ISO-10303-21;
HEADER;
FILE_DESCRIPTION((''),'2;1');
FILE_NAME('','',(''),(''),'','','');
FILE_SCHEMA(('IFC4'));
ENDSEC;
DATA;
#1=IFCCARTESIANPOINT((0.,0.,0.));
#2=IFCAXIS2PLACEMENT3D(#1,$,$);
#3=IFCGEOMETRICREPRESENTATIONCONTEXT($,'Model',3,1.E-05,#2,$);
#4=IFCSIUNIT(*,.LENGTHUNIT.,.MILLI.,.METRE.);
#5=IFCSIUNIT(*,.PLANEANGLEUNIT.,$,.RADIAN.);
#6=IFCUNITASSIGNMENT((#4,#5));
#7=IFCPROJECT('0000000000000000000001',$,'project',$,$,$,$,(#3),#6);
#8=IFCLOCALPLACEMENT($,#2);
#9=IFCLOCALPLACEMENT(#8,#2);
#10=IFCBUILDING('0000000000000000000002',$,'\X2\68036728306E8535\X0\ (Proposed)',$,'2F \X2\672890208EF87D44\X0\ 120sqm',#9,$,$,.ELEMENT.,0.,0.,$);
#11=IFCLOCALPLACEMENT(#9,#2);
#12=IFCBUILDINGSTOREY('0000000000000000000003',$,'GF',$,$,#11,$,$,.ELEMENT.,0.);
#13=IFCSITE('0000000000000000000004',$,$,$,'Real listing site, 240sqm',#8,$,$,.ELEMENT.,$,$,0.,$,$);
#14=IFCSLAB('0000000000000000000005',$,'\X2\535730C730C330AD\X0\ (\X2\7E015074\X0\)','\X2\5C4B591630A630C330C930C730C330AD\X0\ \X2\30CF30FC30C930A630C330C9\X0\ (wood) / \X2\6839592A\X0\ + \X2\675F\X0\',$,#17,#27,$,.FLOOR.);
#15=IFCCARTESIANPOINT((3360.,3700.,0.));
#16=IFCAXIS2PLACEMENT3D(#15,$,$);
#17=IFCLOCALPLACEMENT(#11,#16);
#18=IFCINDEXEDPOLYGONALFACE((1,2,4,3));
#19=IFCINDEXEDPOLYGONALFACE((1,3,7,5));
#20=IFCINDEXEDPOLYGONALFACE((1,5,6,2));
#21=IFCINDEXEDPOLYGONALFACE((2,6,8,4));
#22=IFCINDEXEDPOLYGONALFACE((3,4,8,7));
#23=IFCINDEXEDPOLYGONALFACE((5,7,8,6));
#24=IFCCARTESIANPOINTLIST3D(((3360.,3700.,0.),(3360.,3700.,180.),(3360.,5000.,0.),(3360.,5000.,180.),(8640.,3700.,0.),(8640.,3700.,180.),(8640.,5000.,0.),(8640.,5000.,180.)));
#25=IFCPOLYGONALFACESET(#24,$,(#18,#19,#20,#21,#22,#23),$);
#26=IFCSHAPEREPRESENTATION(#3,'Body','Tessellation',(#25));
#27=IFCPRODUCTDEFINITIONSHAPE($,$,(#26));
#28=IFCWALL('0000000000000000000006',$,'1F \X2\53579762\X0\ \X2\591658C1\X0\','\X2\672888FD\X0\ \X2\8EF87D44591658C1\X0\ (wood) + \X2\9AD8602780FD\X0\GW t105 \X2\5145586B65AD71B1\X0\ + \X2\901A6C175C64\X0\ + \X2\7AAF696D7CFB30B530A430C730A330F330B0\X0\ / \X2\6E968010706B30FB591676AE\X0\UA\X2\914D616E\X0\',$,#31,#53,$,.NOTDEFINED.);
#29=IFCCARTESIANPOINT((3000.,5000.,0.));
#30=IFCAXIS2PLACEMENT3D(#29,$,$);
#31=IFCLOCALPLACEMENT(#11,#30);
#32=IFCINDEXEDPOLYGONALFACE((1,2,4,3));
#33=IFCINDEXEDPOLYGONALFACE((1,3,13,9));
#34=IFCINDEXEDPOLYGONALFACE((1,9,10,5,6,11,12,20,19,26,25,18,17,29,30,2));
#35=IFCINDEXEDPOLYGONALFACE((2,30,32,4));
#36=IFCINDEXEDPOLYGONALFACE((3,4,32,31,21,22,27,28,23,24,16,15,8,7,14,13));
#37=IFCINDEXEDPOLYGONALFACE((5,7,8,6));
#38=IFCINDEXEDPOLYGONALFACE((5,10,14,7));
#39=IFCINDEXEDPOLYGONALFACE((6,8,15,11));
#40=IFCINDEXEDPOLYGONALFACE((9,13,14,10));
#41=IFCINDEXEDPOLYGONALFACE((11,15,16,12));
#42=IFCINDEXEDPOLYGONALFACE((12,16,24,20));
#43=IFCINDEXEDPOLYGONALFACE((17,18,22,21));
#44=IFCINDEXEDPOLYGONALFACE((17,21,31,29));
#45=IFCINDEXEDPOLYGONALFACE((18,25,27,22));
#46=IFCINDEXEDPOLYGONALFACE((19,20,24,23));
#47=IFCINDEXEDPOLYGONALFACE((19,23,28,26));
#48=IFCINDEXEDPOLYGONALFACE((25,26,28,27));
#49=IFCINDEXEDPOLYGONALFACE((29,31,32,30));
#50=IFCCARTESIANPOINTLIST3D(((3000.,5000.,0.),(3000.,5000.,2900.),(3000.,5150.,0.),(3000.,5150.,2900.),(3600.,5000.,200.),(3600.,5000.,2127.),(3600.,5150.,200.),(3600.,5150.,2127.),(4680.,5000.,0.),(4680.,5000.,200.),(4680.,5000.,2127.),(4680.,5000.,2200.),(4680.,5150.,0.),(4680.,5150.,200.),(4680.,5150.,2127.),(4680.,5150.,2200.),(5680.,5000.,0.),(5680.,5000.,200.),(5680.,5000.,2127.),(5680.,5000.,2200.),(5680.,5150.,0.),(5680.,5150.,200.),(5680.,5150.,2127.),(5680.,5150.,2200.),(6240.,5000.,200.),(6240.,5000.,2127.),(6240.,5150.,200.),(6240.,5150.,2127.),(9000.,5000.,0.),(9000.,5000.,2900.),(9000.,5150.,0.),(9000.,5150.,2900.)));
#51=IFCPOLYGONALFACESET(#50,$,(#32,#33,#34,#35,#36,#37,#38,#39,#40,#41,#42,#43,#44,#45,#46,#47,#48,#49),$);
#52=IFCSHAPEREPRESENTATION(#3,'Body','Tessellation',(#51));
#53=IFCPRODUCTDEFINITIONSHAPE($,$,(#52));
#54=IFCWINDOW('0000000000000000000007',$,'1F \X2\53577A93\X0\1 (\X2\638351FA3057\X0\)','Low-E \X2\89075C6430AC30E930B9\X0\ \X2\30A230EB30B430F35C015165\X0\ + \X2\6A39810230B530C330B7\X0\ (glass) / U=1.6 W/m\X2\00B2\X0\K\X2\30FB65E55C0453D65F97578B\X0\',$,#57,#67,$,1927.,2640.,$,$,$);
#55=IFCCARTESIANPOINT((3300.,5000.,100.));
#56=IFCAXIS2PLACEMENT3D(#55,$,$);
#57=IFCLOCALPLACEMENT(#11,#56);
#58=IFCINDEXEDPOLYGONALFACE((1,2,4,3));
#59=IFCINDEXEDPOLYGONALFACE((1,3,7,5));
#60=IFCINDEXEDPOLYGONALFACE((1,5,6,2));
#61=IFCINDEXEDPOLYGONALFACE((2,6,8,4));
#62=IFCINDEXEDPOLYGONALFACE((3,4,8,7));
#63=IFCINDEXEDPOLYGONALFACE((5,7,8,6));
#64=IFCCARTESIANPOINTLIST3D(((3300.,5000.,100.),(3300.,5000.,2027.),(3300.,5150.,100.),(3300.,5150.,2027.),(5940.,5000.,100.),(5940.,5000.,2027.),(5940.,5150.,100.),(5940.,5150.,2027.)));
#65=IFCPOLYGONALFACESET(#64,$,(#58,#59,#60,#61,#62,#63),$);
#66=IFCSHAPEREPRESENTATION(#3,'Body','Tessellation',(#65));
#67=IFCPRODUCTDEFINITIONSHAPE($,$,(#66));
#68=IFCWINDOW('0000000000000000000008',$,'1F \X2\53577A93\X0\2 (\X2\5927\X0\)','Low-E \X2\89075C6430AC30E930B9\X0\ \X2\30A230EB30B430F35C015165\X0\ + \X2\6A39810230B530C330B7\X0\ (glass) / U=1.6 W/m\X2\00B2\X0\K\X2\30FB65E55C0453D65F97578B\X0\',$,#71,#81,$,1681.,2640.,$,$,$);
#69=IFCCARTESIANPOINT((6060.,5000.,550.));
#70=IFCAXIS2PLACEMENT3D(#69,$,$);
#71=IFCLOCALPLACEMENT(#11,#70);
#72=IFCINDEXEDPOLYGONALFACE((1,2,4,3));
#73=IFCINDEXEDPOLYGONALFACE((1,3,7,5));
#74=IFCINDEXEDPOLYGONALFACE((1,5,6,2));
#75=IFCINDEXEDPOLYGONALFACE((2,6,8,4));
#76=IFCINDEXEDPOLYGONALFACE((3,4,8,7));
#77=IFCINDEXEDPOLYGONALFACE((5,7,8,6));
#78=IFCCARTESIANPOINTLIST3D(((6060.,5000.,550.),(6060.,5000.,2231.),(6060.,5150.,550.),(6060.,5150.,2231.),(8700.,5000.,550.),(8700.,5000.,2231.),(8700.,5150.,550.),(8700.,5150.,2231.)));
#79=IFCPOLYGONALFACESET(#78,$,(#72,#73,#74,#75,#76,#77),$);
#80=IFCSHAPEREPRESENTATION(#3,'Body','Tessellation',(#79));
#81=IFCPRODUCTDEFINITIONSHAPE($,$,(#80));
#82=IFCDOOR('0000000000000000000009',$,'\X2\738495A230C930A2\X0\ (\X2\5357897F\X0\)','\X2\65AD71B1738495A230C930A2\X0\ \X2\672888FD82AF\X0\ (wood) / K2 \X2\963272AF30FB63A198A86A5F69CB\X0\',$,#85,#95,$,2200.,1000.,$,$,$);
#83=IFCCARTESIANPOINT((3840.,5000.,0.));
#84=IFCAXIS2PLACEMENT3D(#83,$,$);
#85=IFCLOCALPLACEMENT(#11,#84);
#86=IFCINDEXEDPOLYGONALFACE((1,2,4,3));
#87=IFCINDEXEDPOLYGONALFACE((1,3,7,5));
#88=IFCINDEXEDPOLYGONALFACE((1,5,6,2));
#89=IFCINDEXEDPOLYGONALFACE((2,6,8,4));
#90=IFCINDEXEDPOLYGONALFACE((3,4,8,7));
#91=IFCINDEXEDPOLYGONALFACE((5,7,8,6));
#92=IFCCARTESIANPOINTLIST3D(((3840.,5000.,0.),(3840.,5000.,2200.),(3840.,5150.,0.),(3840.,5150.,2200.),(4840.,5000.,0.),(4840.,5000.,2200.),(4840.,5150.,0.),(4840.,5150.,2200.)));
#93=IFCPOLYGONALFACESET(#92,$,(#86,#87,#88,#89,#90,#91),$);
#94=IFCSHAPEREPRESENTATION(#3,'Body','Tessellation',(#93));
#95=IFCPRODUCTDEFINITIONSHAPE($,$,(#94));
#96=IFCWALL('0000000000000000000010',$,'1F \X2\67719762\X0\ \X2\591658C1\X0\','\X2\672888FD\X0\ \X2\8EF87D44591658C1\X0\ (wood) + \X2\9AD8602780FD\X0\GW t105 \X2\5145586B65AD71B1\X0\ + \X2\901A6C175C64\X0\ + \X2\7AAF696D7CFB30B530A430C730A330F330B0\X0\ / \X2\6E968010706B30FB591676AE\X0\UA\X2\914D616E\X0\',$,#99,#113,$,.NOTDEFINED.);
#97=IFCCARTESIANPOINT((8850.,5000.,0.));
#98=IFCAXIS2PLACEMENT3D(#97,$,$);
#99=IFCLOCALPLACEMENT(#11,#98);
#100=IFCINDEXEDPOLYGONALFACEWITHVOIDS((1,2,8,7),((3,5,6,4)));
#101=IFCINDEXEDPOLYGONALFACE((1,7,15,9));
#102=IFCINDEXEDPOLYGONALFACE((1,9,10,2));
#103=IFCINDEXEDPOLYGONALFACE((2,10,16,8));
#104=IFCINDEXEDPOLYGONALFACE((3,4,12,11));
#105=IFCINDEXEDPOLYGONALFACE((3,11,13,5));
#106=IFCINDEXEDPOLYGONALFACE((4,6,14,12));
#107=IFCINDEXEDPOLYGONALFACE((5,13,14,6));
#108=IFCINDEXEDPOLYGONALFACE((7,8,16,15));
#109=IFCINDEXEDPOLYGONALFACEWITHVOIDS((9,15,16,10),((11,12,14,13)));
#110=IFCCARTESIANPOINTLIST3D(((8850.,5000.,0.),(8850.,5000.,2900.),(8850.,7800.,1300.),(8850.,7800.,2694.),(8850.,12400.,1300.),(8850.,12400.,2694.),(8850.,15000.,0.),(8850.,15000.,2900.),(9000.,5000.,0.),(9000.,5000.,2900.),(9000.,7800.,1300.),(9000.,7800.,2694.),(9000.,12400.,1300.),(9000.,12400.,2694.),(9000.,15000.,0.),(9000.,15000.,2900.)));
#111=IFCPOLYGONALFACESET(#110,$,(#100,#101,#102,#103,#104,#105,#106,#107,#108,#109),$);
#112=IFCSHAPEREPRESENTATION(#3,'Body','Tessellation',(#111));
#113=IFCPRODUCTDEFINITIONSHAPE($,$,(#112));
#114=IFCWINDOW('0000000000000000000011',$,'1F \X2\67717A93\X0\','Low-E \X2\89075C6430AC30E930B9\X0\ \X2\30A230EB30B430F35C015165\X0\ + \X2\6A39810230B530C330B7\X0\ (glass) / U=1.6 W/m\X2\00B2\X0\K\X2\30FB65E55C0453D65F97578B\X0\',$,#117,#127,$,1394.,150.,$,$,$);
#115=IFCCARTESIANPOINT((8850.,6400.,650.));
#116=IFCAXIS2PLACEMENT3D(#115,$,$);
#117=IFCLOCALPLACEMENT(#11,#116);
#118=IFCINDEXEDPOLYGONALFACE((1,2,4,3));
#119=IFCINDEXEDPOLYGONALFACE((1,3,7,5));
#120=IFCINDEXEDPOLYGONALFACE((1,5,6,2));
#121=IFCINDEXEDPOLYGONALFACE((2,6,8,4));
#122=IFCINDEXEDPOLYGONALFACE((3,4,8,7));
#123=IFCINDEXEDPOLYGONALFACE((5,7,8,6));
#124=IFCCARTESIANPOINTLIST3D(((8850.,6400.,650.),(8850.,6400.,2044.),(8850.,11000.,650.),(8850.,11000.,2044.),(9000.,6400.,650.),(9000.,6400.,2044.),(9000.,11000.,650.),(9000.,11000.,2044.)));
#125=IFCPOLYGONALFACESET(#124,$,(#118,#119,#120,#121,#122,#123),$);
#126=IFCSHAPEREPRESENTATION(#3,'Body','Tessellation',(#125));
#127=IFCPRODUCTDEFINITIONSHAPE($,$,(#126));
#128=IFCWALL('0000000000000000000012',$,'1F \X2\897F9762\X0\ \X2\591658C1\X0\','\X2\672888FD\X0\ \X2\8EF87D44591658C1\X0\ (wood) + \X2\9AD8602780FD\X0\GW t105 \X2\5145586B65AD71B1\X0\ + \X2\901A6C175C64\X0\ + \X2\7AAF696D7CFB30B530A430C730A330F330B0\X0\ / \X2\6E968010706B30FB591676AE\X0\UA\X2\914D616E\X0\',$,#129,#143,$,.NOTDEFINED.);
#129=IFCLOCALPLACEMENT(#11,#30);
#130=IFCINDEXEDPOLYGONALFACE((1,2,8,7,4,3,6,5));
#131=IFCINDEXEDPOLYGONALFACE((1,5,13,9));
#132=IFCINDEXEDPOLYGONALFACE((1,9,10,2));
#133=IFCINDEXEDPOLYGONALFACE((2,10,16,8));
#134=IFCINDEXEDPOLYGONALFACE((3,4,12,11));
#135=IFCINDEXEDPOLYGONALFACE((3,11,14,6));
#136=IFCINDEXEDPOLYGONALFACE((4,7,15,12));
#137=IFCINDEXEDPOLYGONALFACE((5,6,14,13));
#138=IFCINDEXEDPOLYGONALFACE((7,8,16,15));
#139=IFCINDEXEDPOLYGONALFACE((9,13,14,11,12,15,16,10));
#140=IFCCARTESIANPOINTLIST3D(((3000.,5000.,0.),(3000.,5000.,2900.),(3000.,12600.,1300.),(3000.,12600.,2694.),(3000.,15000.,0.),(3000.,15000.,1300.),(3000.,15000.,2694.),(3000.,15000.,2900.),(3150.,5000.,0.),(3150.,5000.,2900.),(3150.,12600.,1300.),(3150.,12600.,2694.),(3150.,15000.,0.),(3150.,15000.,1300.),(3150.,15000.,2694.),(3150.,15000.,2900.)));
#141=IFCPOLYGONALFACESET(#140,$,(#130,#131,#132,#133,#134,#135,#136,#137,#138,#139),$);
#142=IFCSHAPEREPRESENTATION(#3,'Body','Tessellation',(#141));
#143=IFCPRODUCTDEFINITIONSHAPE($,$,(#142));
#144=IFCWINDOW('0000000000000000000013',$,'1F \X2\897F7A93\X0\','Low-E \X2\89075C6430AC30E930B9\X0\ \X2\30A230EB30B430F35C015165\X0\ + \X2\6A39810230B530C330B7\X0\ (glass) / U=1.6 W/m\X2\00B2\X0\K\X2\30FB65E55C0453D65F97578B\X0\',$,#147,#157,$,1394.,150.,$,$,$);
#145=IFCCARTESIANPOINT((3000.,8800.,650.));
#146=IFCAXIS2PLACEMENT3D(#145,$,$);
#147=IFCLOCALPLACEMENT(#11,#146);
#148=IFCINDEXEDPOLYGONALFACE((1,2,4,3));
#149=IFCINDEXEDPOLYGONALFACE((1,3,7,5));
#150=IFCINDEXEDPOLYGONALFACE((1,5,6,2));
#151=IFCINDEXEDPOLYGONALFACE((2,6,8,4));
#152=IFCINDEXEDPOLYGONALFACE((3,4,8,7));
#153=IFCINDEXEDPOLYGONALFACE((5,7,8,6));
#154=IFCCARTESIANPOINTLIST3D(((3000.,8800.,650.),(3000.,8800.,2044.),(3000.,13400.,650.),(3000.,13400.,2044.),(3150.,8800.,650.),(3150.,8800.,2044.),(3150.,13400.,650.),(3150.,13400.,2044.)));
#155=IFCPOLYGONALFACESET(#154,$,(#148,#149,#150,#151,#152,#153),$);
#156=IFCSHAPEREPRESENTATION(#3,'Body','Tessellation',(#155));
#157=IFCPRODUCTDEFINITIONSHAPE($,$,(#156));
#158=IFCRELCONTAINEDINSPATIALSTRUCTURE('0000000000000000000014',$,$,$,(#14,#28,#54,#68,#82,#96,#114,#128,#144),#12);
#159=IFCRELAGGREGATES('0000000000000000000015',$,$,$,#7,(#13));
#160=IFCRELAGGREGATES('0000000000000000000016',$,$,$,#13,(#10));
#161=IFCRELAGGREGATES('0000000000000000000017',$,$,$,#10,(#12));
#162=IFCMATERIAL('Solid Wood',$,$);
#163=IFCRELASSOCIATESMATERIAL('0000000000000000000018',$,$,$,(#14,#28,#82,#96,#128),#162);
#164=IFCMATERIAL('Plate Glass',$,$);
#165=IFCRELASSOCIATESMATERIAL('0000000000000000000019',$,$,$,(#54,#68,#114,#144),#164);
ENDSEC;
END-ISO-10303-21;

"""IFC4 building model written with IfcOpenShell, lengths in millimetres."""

from ifc_helpers import new_model, si_unit, frame, frame_2d, origin, place, context, project, spatial, rectangle, extrude, material, element, fill, save


model = new_model("IFC4")

# Units and contexts
model_context = context("Model", 3, precision=1e-05, world=origin())
ifc_project = project(units=[si_unit("LENGTHUNIT", "METRE", prefix="MILLI"), si_unit("PLANEANGLEUNIT", "RADIAN")], contexts=[model_context])

# Site, building, storey
site_placement = place(None, origin())
site = spatial("IfcSite", under=ifc_project, at=site_placement, ObjectType="Real listing site, 240sqm", CompositionType="ELEMENT", RefElevation=0.0)
building_placement = place(site_placement, origin())
building = spatial("IfcBuilding", under=site, at=building_placement, Name="栃木の蔵 (Proposed)", ObjectType="2F 木造軸組 120sqm", CompositionType="ELEMENT", ElevationOfRefHeight=0.0, ElevationOfTerrain=0.0)
storey_placement = place(building_placement, origin())
storey = spatial("IfcBuildingStorey", under=building, at=storey_placement, Name="GF", CompositionType="ELEMENT", Elevation=0.0)

# Slab
ifc_material_1 = material(Name="Solid Wood")
slab_1_placement = place(storey_placement, frame((3360.0, 3700.0, 0.0)))
element("IfcSlab", 1, at=slab_1_placement, inside=storey, material=ifc_material_1, Name="南デッキ (縁側)", Description="屋外ウッドデッキ ハードウッド (wood) / 根太 + 束", PredefinedType="FLOOR", context=model_context, shape_type="SweptSolid", body=[
    extrude(rectangle(XDim=5280.0, YDim=1300.0, at=frame_2d((2640.0, 650.0))), frame((3360.0, 3700.0, 0.0)), (0.0, 0.0, 1.0), 180.0),
])

# Wall, openings, windows, door
wall_1_placement = place(storey_placement, frame((3000.0, 5000.0, 0.0)))
wall_1 = element("IfcWall", 2, at=wall_1_placement, inside=storey, material=ifc_material_1, Name="1F 南面 外壁", Description="木製 軸組外壁 (wood) + 高性能GW t105 充填断熱 + 通気層 + 窯業系サイディング / 準耐火・外皮UA配慮", PredefinedType="NOTDEFINED", context=model_context, shape_type="SweptSolid", body=[
    extrude(rectangle(XDim=6000.0, YDim=150.0, at=frame_2d((3000.0, 75.0))), frame((3000.0, 5000.0, 0.0)), (0.0, 0.0, 1.0), 2900.0),
])
opening_1_placement = place(storey_placement, frame((3300.0, 5000.0, 100.0)))
opening_1 = element("IfcOpeningElement", 3, at=opening_1_placement, cuts=wall_1, PredefinedType="NOTDEFINED", context=model_context, shape_type="SweptSolid", body=[
    extrude(rectangle(XDim=2640.0, YDim=150.0, at=frame_2d((1320.0, 75.0))), frame((3300.0, 5000.0, 100.0)), (0.0, 0.0, 1.0), 1927.0),
])
opening_2_placement = place(storey_placement, frame((6060.0, 5000.0, 550.0)))
opening_2 = element("IfcOpeningElement", 4, at=opening_2_placement, cuts=wall_1, PredefinedType="NOTDEFINED", context=model_context, shape_type="SweptSolid", body=[
    extrude(rectangle(XDim=2640.0, YDim=150.0, at=frame_2d((1320.0, 75.0))), frame((6060.0, 5000.0, 550.0)), (0.0, 0.0, 1.0), 1681.0),
])
opening_3_placement = place(storey_placement, frame((3840.0, 5000.0, 0.0)))
opening_3 = element("IfcOpeningElement", 5, at=opening_3_placement, cuts=wall_1, PredefinedType="NOTDEFINED", context=model_context, shape_type="SweptSolid", body=[
    extrude(rectangle(XDim=1000.0, YDim=150.0, at=frame_2d((500.0, 75.0))), frame((3840.0, 5000.0, 0.0)), (0.0, 0.0, 1.0), 2200.0),
])
ifc_material_2 = material(Name="Plate Glass")
window_1_placement = place(storey_placement, frame((3300.0, 5000.0, 100.0)))
window_1 = element("IfcWindow", 6, at=window_1_placement, inside=storey, material=ifc_material_2, Name="1F 南窓1 (掃出し)", Description="Low-E 複層ガラス アルゴン封入 + 樹脂サッシ (glass) / U=1.6 W/m²K・日射取得型", OverallHeight=1927.0, OverallWidth=2640.0, context=model_context, shape_type="SweptSolid", body=[
    extrude(rectangle(XDim=2640.0, YDim=150.0, at=frame_2d((1320.0, 75.0))), frame((3300.0, 5000.0, 100.0)), (0.0, 0.0, 1.0), 1927.0),
])
fill(opening_1, window_1)
window_2_placement = place(storey_placement, frame((6060.0, 5000.0, 550.0)))
window_2 = element("IfcWindow", 7, at=window_2_placement, inside=storey, material=ifc_material_2, Name="1F 南窓2 (大)", Description="Low-E 複層ガラス アルゴン封入 + 樹脂サッシ (glass) / U=1.6 W/m²K・日射取得型", OverallHeight=1681.0, OverallWidth=2640.0, context=model_context, shape_type="SweptSolid", body=[
    extrude(rectangle(XDim=2640.0, YDim=150.0, at=frame_2d((1320.0, 75.0))), frame((6060.0, 5000.0, 550.0)), (0.0, 0.0, 1.0), 1681.0),
])
fill(opening_2, window_2)
door_placement = place(storey_placement, frame((3840.0, 5000.0, 0.0)))
door = element("IfcDoor", 8, at=door_placement, inside=storey, material=ifc_material_1, Name="玄関ドア (南西)", Description="断熱玄関ドア 木製芯 (wood) / K2 防犯・採風機構", OverallHeight=2200.0, OverallWidth=1000.0, context=model_context, shape_type="SweptSolid", body=[
    extrude(rectangle(XDim=1000.0, YDim=150.0, at=frame_2d((500.0, 75.0))), frame((3840.0, 5000.0, 0.0)), (0.0, 0.0, 1.0), 2200.0),
])
fill(opening_3, door)

# Walls, openings, windows
wall_2_placement = place(storey_placement, frame((8850.0, 5000.0, 0.0)))
wall_2 = element("IfcWall", 9, at=wall_2_placement, inside=storey, material=ifc_material_1, Name="1F 東面 外壁", Description="木製 軸組外壁 (wood) + 高性能GW t105 充填断熱 + 通気層 + 窯業系サイディング / 準耐火・外皮UA配慮", PredefinedType="NOTDEFINED", context=model_context, shape_type="SweptSolid", body=[
    extrude(rectangle(XDim=150.0, YDim=10000.0, at=frame_2d((75.0, 5000.0))), frame((8850.0, 5000.0, 0.0)), (0.0, 0.0, 1.0), 2900.0),
])
opening_4_placement = place(storey_placement, frame((8850.0, 6400.0, 650.0)))
opening_4 = element("IfcOpeningElement", 10, at=opening_4_placement, cuts=wall_2, PredefinedType="NOTDEFINED", context=model_context, shape_type="SweptSolid", body=[
    extrude(rectangle(XDim=150.0, YDim=4600.0, at=frame_2d((75.0, 2300.0))), frame((8850.0, 6400.0, 650.0)), (0.0, 0.0, 1.0), 1394.0),
])
window_3_placement = place(storey_placement, frame((8850.0, 6400.0, 650.0)))
window_3 = element("IfcWindow", 11, at=window_3_placement, inside=storey, material=ifc_material_2, Name="1F 東窓", Description="Low-E 複層ガラス アルゴン封入 + 樹脂サッシ (glass) / U=1.6 W/m²K・日射取得型", OverallHeight=1394.0, OverallWidth=150.0, context=model_context, shape_type="SweptSolid", body=[
    extrude(rectangle(XDim=150.0, YDim=4600.0, at=frame_2d((75.0, 2300.0))), frame((8850.0, 6400.0, 650.0)), (0.0, 0.0, 1.0), 1394.0),
])
fill(opening_4, window_3)
wall_3_placement = place(storey_placement, frame((3000.0, 5000.0, 0.0)))
wall_3 = element("IfcWall", 12, at=wall_3_placement, inside=storey, material=ifc_material_1, Name="1F 西面 外壁", Description="木製 軸組外壁 (wood) + 高性能GW t105 充填断熱 + 通気層 + 窯業系サイディング / 準耐火・外皮UA配慮", PredefinedType="NOTDEFINED", context=model_context, shape_type="SweptSolid", body=[
    extrude(rectangle(XDim=150.0, YDim=10000.0, at=frame_2d((75.0, 5000.0))), frame((3000.0, 5000.0, 0.0)), (0.0, 0.0, 1.0), 2900.0),
])
opening_5_placement = place(storey_placement, frame((3000.0, 8800.0, 650.0)))
opening_5 = element("IfcOpeningElement", 13, at=opening_5_placement, cuts=wall_3, PredefinedType="NOTDEFINED", context=model_context, shape_type="SweptSolid", body=[
    extrude(rectangle(XDim=150.0, YDim=4600.0, at=frame_2d((75.0, 2300.0))), frame((3000.0, 8800.0, 650.0)), (0.0, 0.0, 1.0), 1394.0),
])
window_4_placement = place(storey_placement, frame((3000.0, 8800.0, 650.0)))
window_4 = element("IfcWindow", 14, at=window_4_placement, inside=storey, material=ifc_material_2, Name="1F 西窓", Description="Low-E 複層ガラス アルゴン封入 + 樹脂サッシ (glass) / U=1.6 W/m²K・日射取得型", OverallHeight=1394.0, OverallWidth=150.0, context=model_context, shape_type="SweptSolid", body=[
    extrude(rectangle(XDim=150.0, YDim=4600.0, at=frame_2d((75.0, 2300.0))), frame((3000.0, 8800.0, 650.0)), (0.0, 0.0, 1.0), 1394.0),
])
fill(opening_5, window_4)

save(model, "model.ifc")
